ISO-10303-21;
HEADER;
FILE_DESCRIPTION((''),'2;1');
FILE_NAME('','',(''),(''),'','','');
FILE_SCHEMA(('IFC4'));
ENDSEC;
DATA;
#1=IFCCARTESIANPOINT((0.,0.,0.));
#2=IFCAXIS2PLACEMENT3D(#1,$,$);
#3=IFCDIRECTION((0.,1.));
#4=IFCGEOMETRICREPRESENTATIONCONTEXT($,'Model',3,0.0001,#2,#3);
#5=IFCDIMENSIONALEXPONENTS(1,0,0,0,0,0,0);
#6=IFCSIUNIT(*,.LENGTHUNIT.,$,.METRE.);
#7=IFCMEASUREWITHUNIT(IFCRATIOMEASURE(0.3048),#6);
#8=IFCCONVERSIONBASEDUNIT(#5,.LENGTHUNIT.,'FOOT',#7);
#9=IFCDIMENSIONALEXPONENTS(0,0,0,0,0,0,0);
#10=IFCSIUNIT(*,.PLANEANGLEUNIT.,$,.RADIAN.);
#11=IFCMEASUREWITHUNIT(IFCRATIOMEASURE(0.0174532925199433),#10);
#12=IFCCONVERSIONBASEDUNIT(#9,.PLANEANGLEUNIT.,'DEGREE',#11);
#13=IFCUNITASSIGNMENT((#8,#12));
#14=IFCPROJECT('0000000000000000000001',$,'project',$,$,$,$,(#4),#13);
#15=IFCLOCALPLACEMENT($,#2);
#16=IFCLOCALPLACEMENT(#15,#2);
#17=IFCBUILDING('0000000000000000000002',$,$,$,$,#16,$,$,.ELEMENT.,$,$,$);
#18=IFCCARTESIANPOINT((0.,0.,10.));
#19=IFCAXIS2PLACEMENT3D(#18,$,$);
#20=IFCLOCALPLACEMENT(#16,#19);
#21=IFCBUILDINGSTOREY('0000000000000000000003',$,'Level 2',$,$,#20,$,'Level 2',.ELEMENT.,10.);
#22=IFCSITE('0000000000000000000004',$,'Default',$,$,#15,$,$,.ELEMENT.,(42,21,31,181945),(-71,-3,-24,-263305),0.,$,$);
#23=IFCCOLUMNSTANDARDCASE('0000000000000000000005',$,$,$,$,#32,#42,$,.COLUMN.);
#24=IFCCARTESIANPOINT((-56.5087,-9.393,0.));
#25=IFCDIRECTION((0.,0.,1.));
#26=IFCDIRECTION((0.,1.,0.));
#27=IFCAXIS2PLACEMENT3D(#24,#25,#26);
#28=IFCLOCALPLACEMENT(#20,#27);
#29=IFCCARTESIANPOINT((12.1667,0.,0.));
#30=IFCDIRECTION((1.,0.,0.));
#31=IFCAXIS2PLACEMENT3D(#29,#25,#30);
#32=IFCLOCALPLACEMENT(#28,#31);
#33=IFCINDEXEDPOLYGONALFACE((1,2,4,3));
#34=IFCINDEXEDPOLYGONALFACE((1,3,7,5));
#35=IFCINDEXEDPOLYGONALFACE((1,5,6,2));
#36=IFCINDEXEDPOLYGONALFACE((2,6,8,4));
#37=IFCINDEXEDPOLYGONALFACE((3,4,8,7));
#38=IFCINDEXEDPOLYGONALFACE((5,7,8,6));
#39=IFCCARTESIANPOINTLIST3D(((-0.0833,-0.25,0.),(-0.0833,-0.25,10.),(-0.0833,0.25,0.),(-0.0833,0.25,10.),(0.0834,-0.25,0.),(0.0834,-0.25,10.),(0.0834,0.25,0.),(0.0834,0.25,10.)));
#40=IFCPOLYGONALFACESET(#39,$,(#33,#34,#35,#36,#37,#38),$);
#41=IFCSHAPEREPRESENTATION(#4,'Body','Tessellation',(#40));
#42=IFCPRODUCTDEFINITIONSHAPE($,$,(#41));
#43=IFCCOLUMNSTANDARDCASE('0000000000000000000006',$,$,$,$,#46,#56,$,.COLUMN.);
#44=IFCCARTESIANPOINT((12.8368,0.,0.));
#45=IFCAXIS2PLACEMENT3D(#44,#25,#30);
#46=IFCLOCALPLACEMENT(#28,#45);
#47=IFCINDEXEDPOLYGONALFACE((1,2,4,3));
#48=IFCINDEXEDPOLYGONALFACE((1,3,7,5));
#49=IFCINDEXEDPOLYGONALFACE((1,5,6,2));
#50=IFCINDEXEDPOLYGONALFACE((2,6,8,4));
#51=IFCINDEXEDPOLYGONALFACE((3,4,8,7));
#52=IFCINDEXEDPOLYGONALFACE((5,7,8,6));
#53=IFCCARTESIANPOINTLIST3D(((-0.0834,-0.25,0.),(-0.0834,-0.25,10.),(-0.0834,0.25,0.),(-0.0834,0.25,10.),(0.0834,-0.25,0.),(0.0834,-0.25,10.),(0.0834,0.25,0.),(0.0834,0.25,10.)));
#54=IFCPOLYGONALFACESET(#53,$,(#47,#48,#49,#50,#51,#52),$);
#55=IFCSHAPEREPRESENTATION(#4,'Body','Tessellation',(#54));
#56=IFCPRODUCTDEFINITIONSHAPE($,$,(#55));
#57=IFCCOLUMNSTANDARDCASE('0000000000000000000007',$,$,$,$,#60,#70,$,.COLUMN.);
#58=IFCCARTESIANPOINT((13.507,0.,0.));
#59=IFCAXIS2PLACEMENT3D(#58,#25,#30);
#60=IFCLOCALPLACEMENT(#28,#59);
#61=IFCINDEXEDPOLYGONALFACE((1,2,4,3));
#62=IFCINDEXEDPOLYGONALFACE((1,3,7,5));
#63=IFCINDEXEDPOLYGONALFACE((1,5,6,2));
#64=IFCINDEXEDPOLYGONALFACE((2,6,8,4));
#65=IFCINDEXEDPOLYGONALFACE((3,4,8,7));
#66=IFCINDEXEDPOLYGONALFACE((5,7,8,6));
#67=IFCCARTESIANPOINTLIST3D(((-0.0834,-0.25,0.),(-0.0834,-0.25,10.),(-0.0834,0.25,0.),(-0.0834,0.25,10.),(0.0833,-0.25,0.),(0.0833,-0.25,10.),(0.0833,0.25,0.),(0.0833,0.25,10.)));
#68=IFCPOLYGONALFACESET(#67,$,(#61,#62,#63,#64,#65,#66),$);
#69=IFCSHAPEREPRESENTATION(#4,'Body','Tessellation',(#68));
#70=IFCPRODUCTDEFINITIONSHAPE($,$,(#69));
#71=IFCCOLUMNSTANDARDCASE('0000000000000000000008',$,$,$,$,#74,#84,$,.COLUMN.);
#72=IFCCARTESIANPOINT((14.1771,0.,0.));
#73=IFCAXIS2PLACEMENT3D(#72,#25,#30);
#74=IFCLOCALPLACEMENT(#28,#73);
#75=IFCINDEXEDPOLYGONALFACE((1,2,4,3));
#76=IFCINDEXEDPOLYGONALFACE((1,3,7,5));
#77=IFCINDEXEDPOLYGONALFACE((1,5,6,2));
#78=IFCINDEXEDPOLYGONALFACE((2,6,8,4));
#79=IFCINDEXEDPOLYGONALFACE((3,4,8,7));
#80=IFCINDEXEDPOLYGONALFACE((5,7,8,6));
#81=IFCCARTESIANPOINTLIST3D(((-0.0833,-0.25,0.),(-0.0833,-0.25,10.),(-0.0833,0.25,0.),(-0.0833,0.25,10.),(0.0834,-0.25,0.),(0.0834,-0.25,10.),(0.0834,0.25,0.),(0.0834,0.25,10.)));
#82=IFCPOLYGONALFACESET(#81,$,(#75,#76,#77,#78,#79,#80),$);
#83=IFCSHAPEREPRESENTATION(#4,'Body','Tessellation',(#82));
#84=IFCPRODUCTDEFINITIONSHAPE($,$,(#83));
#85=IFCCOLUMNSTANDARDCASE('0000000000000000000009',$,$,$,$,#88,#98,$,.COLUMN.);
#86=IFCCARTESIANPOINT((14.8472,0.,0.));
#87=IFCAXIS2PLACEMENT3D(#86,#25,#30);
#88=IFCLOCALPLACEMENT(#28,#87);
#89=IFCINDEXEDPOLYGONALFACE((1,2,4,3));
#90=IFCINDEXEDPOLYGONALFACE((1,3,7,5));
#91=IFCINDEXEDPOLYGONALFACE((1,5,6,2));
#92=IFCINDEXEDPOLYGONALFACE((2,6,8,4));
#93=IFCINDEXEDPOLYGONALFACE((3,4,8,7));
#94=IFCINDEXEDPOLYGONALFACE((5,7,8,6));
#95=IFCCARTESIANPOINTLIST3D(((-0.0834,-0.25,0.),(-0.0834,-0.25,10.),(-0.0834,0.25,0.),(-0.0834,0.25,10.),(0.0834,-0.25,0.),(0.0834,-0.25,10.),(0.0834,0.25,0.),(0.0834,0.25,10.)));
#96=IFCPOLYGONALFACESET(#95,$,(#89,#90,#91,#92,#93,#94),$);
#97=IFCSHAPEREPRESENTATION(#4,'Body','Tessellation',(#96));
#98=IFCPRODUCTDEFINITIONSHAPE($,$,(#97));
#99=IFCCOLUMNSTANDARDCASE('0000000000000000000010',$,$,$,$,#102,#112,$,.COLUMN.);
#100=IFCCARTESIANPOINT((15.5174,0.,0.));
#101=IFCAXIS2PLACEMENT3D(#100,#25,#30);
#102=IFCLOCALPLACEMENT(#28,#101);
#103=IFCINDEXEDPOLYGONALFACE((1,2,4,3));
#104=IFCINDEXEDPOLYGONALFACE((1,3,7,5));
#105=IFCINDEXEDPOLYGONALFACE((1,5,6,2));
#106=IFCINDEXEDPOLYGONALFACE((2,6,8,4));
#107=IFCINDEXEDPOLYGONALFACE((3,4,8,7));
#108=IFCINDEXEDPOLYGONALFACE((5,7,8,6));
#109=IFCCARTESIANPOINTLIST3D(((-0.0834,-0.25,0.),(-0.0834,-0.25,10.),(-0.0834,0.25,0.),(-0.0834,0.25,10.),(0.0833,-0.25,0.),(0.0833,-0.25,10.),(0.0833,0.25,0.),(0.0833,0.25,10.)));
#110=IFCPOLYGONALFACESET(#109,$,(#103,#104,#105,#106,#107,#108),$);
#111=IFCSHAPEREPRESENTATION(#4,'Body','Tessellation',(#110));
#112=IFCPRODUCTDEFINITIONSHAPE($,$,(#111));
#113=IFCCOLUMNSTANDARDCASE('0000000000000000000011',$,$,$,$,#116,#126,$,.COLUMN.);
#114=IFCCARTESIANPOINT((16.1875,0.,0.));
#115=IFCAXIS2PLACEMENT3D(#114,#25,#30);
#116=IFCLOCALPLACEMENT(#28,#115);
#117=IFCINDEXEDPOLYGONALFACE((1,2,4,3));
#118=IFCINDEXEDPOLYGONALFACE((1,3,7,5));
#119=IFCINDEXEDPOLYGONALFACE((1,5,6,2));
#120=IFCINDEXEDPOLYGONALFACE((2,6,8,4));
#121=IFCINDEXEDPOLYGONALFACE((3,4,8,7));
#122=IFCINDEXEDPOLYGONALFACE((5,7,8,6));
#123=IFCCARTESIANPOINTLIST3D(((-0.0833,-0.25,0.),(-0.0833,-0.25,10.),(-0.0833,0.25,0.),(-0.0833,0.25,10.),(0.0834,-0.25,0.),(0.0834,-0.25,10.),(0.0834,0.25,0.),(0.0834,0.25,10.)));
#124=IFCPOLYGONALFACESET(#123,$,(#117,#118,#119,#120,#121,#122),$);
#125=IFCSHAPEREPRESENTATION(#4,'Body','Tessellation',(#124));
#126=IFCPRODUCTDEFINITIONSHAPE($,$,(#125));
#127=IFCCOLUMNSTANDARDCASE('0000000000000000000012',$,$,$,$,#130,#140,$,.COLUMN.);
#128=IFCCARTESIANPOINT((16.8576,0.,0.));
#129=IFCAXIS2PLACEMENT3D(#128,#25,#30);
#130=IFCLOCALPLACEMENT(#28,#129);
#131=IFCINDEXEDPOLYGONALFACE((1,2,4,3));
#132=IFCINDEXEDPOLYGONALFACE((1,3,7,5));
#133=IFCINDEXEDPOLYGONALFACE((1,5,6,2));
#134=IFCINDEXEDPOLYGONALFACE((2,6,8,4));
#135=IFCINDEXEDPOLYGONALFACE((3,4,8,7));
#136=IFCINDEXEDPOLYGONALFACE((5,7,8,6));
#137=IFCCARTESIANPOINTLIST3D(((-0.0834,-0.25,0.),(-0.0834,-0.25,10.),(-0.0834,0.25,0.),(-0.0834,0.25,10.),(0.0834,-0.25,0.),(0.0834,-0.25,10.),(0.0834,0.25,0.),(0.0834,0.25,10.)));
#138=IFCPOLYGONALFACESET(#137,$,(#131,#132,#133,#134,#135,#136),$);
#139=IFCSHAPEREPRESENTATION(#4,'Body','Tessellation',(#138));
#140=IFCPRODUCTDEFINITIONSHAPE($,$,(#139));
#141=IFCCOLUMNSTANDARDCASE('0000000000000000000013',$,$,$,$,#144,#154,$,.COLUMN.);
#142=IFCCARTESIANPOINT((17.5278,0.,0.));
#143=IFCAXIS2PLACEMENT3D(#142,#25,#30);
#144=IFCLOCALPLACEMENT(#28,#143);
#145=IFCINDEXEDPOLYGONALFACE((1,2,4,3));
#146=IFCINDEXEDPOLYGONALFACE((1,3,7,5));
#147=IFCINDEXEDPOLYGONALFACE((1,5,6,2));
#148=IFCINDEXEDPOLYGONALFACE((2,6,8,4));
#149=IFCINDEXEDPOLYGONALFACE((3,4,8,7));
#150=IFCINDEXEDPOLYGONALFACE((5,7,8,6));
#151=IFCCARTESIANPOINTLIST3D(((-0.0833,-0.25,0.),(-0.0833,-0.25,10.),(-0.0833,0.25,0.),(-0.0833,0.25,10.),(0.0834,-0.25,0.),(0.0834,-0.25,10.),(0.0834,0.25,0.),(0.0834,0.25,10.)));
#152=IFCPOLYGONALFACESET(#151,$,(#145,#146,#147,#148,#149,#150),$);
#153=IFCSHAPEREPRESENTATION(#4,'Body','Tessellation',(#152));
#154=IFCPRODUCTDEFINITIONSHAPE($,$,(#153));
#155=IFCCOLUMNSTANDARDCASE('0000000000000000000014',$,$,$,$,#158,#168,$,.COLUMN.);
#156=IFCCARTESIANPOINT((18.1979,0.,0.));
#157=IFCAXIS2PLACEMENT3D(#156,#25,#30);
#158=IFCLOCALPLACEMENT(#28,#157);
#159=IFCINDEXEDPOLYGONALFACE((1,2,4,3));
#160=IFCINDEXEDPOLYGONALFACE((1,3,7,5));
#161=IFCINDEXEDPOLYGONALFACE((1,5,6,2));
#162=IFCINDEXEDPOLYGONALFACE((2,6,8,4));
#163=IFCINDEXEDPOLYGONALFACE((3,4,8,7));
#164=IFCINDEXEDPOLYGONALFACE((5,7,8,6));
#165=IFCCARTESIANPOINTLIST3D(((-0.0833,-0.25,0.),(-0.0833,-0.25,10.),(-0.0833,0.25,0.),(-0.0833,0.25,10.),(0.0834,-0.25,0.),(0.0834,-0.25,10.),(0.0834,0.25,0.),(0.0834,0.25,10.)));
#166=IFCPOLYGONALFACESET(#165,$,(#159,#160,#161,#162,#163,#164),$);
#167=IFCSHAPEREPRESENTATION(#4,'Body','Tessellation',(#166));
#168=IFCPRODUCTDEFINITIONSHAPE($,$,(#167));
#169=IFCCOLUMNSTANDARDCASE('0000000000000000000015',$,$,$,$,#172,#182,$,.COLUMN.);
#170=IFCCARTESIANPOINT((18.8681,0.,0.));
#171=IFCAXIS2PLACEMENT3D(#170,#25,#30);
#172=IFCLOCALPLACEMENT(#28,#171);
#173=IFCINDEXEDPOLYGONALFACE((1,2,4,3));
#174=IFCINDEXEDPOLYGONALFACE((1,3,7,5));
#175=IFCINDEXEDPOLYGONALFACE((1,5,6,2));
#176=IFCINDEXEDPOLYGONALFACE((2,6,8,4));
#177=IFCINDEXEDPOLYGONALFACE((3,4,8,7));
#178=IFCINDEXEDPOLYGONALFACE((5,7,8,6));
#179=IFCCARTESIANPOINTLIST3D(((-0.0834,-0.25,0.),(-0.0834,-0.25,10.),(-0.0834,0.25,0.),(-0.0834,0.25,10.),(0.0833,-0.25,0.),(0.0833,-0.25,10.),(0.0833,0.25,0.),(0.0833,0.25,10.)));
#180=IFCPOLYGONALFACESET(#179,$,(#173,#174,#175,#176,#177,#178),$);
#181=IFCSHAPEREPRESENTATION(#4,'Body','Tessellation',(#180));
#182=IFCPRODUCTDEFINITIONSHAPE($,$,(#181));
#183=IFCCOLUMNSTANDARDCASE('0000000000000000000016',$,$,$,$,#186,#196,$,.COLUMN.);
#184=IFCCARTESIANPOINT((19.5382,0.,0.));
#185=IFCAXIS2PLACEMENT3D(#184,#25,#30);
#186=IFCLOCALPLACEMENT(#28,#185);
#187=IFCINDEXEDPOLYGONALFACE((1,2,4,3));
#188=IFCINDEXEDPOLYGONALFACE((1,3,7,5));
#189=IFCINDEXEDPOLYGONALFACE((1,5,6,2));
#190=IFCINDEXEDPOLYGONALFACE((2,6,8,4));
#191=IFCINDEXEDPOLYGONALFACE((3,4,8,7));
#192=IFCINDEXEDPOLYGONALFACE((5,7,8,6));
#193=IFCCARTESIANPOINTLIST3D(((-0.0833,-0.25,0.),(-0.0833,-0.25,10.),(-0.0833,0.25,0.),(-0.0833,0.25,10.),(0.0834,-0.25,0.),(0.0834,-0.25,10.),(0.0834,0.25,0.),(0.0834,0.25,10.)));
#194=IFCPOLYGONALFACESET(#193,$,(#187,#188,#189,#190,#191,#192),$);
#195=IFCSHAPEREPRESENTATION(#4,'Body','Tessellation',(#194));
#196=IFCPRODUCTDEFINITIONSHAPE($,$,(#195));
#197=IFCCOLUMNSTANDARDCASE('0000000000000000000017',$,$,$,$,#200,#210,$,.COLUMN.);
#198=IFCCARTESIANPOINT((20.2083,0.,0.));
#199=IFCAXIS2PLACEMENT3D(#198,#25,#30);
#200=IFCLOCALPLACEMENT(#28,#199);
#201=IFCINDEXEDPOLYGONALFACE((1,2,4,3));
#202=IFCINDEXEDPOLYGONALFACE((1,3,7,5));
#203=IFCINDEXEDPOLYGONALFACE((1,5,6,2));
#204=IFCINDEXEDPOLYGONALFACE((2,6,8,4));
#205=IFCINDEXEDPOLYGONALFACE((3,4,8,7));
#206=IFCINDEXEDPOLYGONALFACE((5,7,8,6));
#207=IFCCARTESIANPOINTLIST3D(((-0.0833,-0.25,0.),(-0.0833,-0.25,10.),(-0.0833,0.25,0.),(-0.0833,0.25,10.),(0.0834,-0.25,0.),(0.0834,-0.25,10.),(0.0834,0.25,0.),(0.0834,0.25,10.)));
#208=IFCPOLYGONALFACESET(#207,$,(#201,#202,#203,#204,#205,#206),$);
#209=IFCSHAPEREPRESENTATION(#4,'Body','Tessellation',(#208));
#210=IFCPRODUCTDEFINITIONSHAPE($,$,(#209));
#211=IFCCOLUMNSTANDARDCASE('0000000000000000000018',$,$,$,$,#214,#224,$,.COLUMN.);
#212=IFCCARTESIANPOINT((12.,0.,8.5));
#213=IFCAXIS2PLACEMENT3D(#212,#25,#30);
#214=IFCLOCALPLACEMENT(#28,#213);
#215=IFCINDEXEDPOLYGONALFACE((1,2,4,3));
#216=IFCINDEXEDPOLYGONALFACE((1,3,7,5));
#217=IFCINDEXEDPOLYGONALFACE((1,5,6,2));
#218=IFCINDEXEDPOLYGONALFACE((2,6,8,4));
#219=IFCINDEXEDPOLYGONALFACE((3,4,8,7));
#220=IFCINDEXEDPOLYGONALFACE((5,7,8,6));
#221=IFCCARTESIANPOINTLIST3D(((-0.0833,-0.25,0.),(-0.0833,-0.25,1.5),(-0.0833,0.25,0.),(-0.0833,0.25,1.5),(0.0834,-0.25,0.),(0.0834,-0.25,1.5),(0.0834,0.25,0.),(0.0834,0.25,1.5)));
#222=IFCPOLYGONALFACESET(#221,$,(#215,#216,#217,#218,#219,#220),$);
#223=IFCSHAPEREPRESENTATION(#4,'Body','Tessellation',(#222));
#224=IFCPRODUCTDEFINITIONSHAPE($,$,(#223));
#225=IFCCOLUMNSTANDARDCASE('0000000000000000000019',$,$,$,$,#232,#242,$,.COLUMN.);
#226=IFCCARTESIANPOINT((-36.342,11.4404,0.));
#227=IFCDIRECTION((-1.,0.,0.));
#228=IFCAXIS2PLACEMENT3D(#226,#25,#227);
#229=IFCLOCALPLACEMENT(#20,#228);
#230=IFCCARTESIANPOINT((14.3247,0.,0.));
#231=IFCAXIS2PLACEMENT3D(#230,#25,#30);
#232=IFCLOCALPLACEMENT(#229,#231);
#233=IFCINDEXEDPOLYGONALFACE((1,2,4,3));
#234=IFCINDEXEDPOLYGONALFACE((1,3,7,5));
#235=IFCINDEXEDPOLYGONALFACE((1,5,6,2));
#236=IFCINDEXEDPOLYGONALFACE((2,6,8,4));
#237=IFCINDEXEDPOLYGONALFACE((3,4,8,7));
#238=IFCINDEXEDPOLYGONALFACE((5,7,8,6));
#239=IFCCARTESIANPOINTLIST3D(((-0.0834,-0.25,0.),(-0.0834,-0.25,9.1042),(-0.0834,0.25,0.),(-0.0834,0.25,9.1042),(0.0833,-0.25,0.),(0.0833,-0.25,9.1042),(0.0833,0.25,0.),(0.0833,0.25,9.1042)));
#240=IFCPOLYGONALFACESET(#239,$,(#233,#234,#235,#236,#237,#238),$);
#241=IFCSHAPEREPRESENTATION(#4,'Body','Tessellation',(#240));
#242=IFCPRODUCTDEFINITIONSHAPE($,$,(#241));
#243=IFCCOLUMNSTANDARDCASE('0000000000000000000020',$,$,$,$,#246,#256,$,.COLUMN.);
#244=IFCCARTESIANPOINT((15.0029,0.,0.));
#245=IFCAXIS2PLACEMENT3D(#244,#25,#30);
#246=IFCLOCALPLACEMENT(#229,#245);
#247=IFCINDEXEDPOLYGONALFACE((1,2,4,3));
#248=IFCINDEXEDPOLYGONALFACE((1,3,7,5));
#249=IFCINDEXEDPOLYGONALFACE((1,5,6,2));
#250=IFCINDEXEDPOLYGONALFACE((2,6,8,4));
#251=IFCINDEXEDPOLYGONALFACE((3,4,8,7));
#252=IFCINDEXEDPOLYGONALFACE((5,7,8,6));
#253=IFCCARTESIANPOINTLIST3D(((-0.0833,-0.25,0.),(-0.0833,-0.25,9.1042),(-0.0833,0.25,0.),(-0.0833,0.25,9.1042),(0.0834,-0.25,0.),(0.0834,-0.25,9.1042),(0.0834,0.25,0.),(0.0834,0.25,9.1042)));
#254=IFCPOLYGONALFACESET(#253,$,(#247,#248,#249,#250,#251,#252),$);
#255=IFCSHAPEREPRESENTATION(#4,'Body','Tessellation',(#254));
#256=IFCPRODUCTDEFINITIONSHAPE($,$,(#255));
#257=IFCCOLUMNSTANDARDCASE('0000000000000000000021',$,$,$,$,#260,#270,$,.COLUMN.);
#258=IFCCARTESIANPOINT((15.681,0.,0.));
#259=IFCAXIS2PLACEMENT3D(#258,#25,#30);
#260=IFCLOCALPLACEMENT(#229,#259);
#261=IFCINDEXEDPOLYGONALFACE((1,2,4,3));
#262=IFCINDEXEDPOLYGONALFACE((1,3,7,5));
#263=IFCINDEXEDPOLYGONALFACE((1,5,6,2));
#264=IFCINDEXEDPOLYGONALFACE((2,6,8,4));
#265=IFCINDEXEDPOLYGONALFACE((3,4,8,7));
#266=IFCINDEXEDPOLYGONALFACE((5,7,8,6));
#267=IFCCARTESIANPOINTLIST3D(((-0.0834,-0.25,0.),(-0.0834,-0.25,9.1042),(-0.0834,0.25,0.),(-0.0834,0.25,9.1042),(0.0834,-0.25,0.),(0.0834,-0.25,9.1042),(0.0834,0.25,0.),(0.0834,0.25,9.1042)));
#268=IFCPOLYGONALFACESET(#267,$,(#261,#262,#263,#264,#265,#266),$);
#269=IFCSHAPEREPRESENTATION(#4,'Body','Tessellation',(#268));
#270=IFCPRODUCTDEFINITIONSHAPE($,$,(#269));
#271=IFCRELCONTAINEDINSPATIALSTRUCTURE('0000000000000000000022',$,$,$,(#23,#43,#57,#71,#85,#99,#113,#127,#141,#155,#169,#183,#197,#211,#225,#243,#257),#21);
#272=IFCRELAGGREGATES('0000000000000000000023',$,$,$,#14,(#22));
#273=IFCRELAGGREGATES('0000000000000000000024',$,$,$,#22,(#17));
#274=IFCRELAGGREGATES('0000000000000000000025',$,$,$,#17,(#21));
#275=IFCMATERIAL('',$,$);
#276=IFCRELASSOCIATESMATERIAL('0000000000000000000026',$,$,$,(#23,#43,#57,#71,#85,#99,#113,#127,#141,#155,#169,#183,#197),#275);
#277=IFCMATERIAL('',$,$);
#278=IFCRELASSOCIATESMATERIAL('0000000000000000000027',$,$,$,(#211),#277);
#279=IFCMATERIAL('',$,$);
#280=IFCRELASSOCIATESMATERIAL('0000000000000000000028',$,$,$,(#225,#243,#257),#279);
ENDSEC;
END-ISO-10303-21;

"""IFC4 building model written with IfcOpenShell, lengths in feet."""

from ifc_helpers import new_model, entity, si_unit, converted_unit, direction, frame, origin, place, context, project, spatial, rectangle, extrude, material, element, save


model = new_model("IFC4")

# Units and contexts
model_context = context("Model", 3, precision=0.0001, world=origin(), true_north=direction((0.0, 1.0)))
ifc_project = project(units=[converted_unit("LENGTHUNIT", "FOOT", entity("IfcRatioMeasure", 0.3048), si_unit("LENGTHUNIT", "METRE"), dimensions=[1, 0, 0, 0, 0, 0, 0]), converted_unit("PLANEANGLEUNIT", "DEGREE", entity("IfcRatioMeasure", 0.0174532925199433), si_unit("PLANEANGLEUNIT", "RADIAN"), dimensions=[0, 0, 0, 0, 0, 0, 0])], contexts=[model_context])

# Site, building, storey
site_placement = place(None, origin())
site = spatial("IfcSite", under=ifc_project, at=site_placement, Name="Default", CompositionType="ELEMENT", RefLatitude=(42, 21, 31, 181945), RefLongitude=(-71, -3, -24, -263305), RefElevation=0.0)
building_placement = place(site_placement, origin())
building = spatial("IfcBuilding", under=site, at=building_placement, CompositionType="ELEMENT")
storey_placement = place(building_placement, frame((0.0, 0.0, 10.0)))
storey = spatial("IfcBuildingStorey", under=building, at=storey_placement, Name="Level 2", LongName="Level 2", CompositionType="ELEMENT", Elevation=10.0)

# Columns
ifc_material_1 = material(Name="")
placement_1 = place(storey_placement, frame((-56.5087, -9.393, 0.0), z_axis=(0.0, 0.0, 1.0), x_axis=(0.0, 1.0, 0.0)))
for number, where, z_axis, x_axis in (
    (1, (12.1667, 0.0, 0.0), (0.0, 0.0, 1.0), (1.0, 0.0, 0.0)),
    (2, (12.8368, 0.0, 0.0), (0.0, 0.0, 1.0), (1.0, 0.0, 0.0)),
    (3, (13.507, 0.0, 0.0), (0.0, 0.0, 1.0), (1.0, 0.0, 0.0)),
    (4, (14.1771, 0.0, 0.0), (0.0, 0.0, 1.0), (1.0, 0.0, 0.0)),
    (5, (14.8472, 0.0, 0.0), (0.0, 0.0, 1.0), (1.0, 0.0, 0.0)),
    (6, (15.5174, 0.0, 0.0), (0.0, 0.0, 1.0), (1.0, 0.0, 0.0)),
    (7, (16.1875, 0.0, 0.0), (0.0, 0.0, 1.0), (1.0, 0.0, 0.0)),
    (8, (16.8576, 0.0, 0.0), (0.0, 0.0, 1.0), (1.0, 0.0, 0.0)),
    (9, (17.5278, 0.0, 0.0), (0.0, 0.0, 1.0), (1.0, 0.0, 0.0)),
    (10, (18.1979, 0.0, 0.0), (0.0, 0.0, 1.0), (1.0, 0.0, 0.0)),
    (11, (18.8681, 0.0, 0.0), (0.0, 0.0, 1.0), (1.0, 0.0, 0.0)),
    (12, (19.5382, 0.0, 0.0), (0.0, 0.0, 1.0), (1.0, 0.0, 0.0)),
    (13, (20.2083, 0.0, 0.0), (0.0, 0.0, 1.0), (1.0, 0.0, 0.0)),
):
    element("IfcColumnStandardCase", number, at=place(placement_1, frame(where, z_axis=z_axis, x_axis=x_axis)), inside=storey, material=ifc_material_1, PredefinedType="COLUMN", context=model_context, shape_type="SweptSolid", body=[
        extrude(rectangle(XDim=0.1667, YDim=0.5), origin(), (0.0, 0.0, 1.0), 10.0),
    ])
ifc_material_2 = material(Name="")
for number, where, z_axis, x_axis in (
    (14, (12.0, 0.0, 8.5), (0.0, 0.0, 1.0), (1.0, 0.0, 0.0)),
):
    element("IfcColumnStandardCase", number, at=place(placement_1, frame(where, z_axis=z_axis, x_axis=x_axis)), inside=storey, material=ifc_material_2, PredefinedType="COLUMN", context=model_context, shape_type="SweptSolid", body=[
        extrude(rectangle(XDim=0.1667, YDim=0.5), origin(), (0.0, 0.0, 1.0), 1.5),
    ])
ifc_material_3 = material(Name="")
placement_2 = place(storey_placement, frame((-36.342, 11.4404, 0.0), z_axis=(0.0, 0.0, 1.0), x_axis=(-1.0, 0.0, 0.0)))
for number, where, z_axis, x_axis in (
    (15, (14.3247, 0.0, 0.0), (0.0, 0.0, 1.0), (1.0, 0.0, 0.0)),
    (16, (15.0029, 0.0, 0.0), (0.0, 0.0, 1.0), (1.0, 0.0, 0.0)),
    (17, (15.681, 0.0, 0.0), (0.0, 0.0, 1.0), (1.0, 0.0, 0.0)),
):
    element("IfcColumnStandardCase", number, at=place(placement_2, frame(where, z_axis=z_axis, x_axis=x_axis)), inside=storey, material=ifc_material_3, PredefinedType="COLUMN", context=model_context, shape_type="SweptSolid", body=[
        extrude(rectangle(XDim=0.1667, YDim=0.5), origin(), (0.0, 0.0, 1.0), 9.1042),
    ])

save(model, "model.ifc")
